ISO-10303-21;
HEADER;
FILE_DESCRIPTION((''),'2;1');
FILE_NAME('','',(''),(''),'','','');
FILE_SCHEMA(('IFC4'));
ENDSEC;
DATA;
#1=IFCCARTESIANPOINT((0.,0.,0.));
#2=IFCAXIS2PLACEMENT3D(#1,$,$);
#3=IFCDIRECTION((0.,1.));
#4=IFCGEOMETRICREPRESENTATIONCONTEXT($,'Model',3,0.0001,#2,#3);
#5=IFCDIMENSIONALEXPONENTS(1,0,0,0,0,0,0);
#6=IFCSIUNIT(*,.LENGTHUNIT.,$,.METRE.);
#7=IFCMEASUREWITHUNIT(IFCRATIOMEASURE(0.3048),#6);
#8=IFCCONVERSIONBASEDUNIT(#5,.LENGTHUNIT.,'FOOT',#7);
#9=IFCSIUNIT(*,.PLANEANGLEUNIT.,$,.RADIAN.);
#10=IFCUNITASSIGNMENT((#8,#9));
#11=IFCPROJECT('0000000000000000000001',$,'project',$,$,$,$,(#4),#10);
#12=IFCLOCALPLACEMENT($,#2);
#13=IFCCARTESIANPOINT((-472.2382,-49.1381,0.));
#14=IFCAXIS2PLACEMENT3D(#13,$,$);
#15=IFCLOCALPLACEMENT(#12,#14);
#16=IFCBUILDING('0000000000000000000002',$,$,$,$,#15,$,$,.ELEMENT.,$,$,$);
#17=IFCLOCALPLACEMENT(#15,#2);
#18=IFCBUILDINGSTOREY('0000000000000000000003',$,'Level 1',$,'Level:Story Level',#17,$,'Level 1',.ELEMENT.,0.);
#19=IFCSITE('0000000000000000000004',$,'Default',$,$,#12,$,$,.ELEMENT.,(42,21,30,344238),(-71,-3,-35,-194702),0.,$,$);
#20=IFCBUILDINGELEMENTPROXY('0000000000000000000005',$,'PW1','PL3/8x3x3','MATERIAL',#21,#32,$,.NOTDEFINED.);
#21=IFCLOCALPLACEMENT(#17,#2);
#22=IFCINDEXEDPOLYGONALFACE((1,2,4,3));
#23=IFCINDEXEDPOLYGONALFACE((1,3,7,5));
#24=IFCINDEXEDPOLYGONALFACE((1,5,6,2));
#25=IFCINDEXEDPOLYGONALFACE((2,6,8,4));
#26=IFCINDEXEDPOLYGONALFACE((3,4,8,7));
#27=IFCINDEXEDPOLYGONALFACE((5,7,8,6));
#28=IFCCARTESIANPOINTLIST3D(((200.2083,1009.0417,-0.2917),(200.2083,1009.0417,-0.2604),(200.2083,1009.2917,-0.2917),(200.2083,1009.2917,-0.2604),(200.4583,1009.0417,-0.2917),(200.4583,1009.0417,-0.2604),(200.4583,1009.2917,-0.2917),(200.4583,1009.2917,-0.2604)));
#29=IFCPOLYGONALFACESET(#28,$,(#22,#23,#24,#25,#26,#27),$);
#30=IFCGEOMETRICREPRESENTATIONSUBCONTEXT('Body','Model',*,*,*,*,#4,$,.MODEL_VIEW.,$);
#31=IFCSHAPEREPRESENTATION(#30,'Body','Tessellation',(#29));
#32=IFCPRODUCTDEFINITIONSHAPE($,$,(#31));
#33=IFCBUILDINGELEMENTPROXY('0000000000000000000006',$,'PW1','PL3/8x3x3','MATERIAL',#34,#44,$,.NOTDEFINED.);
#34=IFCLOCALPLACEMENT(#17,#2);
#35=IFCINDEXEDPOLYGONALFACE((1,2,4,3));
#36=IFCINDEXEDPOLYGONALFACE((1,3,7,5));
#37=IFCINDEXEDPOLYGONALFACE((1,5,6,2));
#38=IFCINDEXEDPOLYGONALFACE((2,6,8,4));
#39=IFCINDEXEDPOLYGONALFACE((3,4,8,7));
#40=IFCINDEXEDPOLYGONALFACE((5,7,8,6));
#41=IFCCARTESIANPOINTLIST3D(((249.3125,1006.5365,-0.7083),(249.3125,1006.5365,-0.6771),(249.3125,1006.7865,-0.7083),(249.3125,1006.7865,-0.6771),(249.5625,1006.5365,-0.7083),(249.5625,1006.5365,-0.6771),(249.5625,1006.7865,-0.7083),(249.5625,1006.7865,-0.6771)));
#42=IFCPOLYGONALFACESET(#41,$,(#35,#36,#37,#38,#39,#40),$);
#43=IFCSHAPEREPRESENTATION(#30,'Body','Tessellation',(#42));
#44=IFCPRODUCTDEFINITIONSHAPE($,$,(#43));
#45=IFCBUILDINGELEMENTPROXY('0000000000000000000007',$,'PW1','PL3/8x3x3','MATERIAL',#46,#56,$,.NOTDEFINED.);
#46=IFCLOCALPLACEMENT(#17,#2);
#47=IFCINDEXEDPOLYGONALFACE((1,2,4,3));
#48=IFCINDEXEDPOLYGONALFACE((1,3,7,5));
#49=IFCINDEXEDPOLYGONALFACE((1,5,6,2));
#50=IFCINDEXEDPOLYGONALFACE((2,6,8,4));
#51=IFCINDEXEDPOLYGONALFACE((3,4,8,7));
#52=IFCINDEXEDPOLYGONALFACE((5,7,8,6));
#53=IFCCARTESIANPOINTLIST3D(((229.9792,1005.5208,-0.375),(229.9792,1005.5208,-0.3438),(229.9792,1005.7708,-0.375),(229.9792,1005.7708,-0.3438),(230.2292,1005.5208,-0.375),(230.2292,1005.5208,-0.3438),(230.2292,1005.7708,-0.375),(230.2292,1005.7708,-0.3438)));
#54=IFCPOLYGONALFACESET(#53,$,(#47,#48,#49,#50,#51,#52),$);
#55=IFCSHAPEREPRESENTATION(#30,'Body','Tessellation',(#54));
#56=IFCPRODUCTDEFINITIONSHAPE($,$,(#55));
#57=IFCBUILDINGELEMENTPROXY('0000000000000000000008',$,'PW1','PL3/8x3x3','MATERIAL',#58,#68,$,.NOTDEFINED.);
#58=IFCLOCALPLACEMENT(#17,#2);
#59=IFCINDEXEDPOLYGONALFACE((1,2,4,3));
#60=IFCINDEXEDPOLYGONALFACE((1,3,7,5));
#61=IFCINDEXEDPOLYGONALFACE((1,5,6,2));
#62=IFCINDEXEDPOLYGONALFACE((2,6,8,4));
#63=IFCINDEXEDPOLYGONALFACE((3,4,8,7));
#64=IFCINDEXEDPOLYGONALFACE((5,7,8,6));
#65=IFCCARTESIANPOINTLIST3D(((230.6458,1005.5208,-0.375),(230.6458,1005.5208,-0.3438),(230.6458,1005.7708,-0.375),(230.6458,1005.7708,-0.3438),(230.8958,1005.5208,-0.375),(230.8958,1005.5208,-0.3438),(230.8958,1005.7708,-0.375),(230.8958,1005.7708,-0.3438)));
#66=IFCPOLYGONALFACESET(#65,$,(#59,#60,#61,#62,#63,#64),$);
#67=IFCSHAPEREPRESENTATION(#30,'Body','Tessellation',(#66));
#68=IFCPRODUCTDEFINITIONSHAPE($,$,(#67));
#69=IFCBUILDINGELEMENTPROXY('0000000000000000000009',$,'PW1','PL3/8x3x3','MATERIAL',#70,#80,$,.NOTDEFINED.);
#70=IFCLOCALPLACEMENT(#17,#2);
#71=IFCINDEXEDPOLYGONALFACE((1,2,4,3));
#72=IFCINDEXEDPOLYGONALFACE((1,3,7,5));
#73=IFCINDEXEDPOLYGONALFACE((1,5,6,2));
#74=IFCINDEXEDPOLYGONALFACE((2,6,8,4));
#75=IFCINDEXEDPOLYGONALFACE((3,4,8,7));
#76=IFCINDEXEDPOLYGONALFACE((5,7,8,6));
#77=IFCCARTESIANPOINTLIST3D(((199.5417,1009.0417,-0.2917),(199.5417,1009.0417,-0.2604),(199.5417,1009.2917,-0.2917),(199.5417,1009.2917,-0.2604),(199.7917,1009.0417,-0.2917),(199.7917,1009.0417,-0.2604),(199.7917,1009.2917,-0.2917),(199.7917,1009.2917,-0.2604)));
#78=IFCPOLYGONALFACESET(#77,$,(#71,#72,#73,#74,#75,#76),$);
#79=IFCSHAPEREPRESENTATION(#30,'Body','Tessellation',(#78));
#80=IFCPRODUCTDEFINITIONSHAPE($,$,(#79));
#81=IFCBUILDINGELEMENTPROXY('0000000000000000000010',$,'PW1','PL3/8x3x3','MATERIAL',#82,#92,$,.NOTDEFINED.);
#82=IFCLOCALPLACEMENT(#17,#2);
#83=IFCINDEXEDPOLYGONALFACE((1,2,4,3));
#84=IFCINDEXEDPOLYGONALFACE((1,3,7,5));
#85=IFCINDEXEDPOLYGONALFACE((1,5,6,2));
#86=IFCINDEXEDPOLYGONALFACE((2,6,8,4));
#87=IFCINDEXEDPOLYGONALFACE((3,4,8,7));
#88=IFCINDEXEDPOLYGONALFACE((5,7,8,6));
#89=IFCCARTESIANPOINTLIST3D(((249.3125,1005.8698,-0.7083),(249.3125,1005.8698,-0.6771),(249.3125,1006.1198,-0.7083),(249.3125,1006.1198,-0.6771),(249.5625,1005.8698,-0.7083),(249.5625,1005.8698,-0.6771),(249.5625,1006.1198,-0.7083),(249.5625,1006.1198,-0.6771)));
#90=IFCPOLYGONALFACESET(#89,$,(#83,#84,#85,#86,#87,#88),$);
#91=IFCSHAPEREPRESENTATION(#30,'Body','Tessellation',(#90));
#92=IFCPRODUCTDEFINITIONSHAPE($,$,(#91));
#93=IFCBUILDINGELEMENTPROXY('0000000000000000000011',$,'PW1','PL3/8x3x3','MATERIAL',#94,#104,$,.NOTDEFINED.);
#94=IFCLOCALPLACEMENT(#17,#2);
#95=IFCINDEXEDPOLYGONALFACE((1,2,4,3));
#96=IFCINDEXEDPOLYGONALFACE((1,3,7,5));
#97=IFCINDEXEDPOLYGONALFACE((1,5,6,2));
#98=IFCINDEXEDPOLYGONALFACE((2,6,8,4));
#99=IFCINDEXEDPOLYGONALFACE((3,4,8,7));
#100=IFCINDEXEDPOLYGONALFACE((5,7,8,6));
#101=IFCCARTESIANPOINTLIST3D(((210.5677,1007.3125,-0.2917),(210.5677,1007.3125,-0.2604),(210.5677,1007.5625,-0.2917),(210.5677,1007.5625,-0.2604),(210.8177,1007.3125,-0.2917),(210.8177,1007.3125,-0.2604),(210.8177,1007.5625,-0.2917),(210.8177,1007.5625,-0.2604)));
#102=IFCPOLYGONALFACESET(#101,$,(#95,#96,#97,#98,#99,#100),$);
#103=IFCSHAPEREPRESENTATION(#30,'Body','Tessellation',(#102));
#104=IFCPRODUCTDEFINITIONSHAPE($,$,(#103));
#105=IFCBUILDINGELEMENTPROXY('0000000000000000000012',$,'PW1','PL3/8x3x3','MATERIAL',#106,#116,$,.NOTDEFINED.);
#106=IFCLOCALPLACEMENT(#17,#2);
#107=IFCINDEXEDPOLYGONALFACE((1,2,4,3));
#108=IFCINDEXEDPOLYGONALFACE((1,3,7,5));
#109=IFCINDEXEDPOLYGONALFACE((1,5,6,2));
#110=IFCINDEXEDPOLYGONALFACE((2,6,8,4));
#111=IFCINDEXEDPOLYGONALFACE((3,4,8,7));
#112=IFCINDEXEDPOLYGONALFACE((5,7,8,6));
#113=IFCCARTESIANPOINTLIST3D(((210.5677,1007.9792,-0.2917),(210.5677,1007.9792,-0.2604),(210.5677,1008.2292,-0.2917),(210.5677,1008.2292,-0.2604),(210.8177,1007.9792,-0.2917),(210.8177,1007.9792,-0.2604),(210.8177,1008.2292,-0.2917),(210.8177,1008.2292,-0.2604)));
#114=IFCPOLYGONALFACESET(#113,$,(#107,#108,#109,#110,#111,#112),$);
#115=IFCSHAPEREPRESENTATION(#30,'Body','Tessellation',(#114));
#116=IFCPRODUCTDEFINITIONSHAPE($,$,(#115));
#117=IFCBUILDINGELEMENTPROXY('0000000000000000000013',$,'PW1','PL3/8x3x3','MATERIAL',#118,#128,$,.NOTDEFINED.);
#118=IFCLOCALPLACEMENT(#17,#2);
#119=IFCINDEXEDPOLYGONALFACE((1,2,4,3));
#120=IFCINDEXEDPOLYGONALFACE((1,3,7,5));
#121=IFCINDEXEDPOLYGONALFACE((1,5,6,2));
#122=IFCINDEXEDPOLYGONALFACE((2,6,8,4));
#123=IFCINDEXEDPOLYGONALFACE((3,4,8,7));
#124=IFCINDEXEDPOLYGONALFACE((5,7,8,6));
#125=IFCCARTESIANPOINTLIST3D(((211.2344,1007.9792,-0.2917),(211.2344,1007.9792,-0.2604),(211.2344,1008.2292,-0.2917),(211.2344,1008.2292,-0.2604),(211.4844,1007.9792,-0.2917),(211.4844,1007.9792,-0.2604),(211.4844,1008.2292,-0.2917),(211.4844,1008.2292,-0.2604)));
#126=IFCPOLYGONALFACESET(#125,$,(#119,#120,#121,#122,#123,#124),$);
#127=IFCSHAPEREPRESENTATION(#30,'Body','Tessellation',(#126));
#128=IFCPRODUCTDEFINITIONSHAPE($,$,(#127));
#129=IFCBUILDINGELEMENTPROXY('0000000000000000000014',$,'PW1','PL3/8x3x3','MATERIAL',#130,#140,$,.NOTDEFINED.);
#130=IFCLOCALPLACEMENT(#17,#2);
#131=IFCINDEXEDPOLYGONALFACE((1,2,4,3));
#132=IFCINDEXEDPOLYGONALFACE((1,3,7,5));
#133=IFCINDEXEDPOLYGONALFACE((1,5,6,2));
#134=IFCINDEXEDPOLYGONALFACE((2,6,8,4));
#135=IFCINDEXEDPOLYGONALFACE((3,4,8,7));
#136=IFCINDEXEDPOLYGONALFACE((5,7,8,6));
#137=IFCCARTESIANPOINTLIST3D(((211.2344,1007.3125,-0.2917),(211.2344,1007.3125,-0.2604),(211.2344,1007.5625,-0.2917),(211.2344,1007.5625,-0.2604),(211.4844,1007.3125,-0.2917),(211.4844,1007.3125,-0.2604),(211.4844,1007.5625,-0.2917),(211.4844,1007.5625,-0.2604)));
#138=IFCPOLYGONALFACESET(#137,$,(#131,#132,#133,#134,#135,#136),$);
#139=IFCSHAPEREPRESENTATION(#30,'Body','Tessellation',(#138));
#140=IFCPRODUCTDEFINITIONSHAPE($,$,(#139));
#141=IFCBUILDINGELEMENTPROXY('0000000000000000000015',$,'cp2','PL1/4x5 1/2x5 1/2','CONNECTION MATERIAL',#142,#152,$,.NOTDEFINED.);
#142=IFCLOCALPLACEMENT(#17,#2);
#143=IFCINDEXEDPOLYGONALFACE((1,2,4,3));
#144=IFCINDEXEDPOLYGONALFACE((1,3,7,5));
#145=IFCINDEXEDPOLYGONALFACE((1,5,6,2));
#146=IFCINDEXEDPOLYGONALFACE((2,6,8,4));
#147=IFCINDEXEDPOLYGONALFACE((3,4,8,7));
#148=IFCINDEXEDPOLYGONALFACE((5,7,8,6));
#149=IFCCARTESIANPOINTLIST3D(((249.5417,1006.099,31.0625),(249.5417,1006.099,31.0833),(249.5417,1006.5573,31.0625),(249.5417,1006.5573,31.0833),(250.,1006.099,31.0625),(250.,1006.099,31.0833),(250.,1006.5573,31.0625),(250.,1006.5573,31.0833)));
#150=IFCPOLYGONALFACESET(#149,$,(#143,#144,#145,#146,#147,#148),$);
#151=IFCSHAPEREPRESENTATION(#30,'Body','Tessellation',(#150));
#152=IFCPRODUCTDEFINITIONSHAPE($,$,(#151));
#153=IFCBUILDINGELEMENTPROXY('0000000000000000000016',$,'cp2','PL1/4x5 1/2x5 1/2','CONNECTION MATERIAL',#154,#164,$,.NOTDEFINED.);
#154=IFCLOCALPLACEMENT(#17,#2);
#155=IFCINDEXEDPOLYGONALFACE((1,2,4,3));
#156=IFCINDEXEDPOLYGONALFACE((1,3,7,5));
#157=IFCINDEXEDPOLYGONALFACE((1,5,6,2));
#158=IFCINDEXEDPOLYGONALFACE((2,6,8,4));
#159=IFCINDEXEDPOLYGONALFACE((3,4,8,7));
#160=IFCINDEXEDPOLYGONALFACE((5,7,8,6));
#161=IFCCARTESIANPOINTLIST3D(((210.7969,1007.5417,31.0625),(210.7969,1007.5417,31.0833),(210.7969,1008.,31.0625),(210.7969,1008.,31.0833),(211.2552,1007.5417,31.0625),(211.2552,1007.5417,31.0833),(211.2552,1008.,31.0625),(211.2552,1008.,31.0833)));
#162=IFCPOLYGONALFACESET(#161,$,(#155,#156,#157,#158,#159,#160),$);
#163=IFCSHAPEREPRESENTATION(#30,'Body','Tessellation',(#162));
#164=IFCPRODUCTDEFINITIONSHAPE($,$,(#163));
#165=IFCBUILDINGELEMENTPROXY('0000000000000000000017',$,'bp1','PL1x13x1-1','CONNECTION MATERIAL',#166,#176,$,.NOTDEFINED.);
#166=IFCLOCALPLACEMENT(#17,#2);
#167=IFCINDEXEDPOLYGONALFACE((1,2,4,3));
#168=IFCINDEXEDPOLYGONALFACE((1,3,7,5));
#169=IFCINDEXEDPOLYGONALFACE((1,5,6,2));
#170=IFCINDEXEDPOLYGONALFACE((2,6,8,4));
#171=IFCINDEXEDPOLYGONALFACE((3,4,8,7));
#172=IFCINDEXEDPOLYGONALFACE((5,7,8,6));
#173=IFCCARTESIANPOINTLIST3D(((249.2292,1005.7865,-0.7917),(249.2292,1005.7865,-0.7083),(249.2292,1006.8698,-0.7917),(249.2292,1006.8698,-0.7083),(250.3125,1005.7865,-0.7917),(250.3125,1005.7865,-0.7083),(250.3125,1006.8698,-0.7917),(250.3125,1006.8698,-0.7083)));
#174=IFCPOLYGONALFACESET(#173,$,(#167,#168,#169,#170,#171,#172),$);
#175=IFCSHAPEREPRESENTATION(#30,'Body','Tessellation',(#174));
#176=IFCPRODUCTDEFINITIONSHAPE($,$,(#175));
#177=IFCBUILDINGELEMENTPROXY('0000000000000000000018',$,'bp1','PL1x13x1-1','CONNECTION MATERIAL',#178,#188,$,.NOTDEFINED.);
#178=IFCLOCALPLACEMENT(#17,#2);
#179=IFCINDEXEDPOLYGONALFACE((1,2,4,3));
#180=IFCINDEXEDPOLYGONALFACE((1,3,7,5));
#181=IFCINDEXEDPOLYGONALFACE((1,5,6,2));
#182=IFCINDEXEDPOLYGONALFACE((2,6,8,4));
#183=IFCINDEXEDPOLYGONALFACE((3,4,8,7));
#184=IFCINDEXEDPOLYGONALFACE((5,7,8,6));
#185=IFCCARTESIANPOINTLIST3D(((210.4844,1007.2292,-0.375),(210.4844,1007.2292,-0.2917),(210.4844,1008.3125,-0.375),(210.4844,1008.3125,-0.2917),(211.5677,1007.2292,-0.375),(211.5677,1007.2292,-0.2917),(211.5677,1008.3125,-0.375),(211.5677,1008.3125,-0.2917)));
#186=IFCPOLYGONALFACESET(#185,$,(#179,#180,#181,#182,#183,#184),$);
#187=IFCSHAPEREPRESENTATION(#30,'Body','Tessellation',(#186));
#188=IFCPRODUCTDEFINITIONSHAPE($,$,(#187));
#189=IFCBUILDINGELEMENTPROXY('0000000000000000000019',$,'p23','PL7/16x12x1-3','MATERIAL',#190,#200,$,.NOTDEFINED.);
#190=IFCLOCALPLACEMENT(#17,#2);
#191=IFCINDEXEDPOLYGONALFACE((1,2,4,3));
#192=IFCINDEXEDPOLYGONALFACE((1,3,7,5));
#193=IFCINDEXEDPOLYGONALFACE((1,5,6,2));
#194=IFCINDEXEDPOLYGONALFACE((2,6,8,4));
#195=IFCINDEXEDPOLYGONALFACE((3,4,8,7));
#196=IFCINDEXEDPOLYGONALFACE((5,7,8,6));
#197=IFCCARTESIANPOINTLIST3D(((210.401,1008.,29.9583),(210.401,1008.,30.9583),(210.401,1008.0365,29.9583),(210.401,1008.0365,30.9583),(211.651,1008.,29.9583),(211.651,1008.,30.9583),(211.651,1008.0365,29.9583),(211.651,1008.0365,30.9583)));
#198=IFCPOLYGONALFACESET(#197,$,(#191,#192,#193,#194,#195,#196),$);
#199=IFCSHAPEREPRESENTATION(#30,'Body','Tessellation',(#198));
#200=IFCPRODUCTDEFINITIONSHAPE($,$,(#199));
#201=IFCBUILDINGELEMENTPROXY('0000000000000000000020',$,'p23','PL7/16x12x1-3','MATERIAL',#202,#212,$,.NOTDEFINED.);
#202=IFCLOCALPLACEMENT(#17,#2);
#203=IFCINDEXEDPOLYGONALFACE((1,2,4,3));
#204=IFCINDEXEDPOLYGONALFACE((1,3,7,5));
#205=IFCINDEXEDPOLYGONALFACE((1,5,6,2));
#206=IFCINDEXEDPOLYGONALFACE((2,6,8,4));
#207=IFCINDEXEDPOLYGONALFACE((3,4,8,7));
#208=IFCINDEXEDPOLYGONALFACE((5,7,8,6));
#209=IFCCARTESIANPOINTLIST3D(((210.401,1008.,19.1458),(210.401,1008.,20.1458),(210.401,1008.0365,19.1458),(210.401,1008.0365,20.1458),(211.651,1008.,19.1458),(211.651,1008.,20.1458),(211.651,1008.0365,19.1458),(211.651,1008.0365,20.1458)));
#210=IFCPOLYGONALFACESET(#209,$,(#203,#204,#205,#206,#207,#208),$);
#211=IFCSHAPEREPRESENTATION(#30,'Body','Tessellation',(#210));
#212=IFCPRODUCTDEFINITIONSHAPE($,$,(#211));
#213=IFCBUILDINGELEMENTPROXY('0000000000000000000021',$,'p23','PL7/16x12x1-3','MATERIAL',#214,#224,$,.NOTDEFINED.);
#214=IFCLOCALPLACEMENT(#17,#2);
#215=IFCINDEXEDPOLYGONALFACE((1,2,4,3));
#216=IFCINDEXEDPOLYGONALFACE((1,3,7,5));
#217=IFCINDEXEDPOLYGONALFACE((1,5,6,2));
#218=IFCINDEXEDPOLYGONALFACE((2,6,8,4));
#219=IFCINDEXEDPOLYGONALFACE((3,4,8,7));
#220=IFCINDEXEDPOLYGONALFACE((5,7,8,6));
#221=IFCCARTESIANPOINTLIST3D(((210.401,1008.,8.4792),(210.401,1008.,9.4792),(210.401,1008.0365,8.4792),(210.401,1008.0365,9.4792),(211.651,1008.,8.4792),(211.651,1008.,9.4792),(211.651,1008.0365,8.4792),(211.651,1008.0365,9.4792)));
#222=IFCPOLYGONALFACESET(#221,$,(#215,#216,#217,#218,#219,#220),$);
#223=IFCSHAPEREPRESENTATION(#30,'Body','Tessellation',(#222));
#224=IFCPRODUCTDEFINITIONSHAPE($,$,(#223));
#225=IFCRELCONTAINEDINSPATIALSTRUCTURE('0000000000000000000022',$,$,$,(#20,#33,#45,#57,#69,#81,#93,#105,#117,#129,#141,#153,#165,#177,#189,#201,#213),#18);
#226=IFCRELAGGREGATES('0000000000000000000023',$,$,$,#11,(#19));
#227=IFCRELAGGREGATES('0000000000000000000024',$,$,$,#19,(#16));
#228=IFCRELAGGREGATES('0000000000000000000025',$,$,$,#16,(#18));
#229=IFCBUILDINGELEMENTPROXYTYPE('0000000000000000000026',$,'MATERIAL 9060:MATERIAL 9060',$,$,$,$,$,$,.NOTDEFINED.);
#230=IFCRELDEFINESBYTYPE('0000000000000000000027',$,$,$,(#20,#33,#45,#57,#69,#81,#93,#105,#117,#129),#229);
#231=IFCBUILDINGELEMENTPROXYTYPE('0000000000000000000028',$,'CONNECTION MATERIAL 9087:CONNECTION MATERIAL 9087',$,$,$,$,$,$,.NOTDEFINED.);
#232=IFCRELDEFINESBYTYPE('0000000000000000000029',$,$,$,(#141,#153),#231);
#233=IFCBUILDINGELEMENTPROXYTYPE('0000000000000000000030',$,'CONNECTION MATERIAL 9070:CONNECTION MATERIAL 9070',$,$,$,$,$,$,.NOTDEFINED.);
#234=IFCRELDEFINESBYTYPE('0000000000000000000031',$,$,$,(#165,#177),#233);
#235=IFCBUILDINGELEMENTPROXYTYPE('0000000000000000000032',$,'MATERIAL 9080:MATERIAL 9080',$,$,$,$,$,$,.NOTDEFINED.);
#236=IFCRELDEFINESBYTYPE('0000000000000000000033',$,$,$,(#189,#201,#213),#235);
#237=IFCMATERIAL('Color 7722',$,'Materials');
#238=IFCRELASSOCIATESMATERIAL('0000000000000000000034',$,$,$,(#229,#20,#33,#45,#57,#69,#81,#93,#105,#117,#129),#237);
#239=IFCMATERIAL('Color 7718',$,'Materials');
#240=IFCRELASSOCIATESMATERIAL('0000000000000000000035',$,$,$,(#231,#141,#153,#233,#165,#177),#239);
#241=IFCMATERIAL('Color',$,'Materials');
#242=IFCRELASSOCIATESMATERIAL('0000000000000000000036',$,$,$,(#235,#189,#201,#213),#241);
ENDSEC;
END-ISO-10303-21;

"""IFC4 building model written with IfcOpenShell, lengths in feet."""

from ifc_helpers import new_model, entity, si_unit, converted_unit, direction, frame, origin, origin_2d_with_axis, place, context, subcontext, project, spatial, rectangle, extrude, source, transform, mapped, material, type_object, type_shapes, element, save


model = new_model("IFC4")

# Units and contexts
model_context = context("Model", 3, precision=0.0001, world=origin(), true_north=direction((0.0, 1.0)))
body_context = subcontext(model_context, "Body", "Model", "MODEL_VIEW")
ifc_project = project(units=[converted_unit("LENGTHUNIT", "FOOT", entity("IfcRatioMeasure", 0.3048), si_unit("LENGTHUNIT", "METRE"), dimensions=[1, 0, 0, 0, 0, 0, 0]), si_unit("PLANEANGLEUNIT", "RADIAN")], contexts=[model_context])

# Site, building, storey
site_placement = place(None, origin())
site = spatial("IfcSite", under=ifc_project, at=site_placement, Name="Default", CompositionType="ELEMENT", RefLatitude=(42, 21, 30, 344238), RefLongitude=(-71, -3, -35, -194702), RefElevation=0.0)
building_placement = place(site_placement, frame((-472.2382, -49.1381, 0.0)))
building = spatial("IfcBuilding", under=site, at=building_placement, CompositionType="ELEMENT")
storey_placement = place(building_placement, origin())
storey = spatial("IfcBuildingStorey", under=building, at=storey_placement, Name="Level 1", ObjectType="Level:Story Level", LongName="Level 1", CompositionType="ELEMENT", Elevation=0.0)

# Building element proxies
ifc_material_1 = material(Name="Color", Category="Materials")
ifc_material_2 = material(Name="Color 7722", Category="Materials")
building_element_proxy_type_1 = type_object("IfcBuildingElementProxyType", Name="MATERIAL 9060:MATERIAL 9060", PredefinedType="NOTDEFINED", material=ifc_material_2)
shared_shape_1 = source(origin(), body_context, "Body", "SweptSolid", [
    extrude(rectangle(XDim=0.25, YDim=0.25, at=origin_2d_with_axis()), frame((0.125, -0.125, 0.0)), (0.0, 0.0, 1.0), 0.0312),
])
type_shapes(building_element_proxy_type_1, [shared_shape_1])
for number, where, z_axis, x_axis, name in (
    (1, (200.2083, 1009.2917, -0.2604), (0.0, 0.0, -1.0), (0.0, -1.0, 0.0), "PW1"),
    (2, (249.3125, 1006.7865, -0.6771), (0.0, 0.0, -1.0), (0.0, -1.0, 0.0), "PW1"),
    (3, (229.9792, 1005.7708, -0.3438), (0.0, 0.0, -1.0), (0.0, -1.0, 0.0), "PW1"),
    (4, (230.6458, 1005.7708, -0.3438), (0.0, 0.0, -1.0), (0.0, -1.0, 0.0), "PW1"),
    (5, (199.5417, 1009.2917, -0.2604), (0.0, 0.0, -1.0), (0.0, -1.0, 0.0), "PW1"),
    (6, (249.3125, 1006.1198, -0.6771), (0.0, 0.0, -1.0), (0.0, -1.0, 0.0), "PW1"),
    (7, (210.5677, 1007.5625, -0.2604), (0.0, 0.0, -1.0), (0.0, -1.0, 0.0), "PW1"),
    (8, (210.5677, 1008.2292, -0.2604), (0.0, 0.0, -1.0), (0.0, -1.0, 0.0), "PW1"),
    (9, (211.2344, 1008.2292, -0.2604), (0.0, 0.0, -1.0), (0.0, -1.0, 0.0), "PW1"),
    (10, (211.2344, 1007.5625, -0.2604), (0.0, 0.0, -1.0), (0.0, -1.0, 0.0), "PW1"),
):
    element("IfcBuildingElementProxy", number, at=place(building_placement, frame(where, z_axis=z_axis, x_axis=x_axis)), inside=storey, type_object=building_element_proxy_type_1, material=ifc_material_2, Name=name, Description="PL3/8x3x3", ObjectType="MATERIAL", PredefinedType="NOTDEFINED", context=body_context, shape_type="MappedRepresentation", body=[
        mapped(shared_shape_1, transform((0.0, 0.0, 0.0), scale=1.0)),
    ])
ifc_material_3 = material(Name="Color 7718", Category="Materials")
building_element_proxy_type_2 = type_object("IfcBuildingElementProxyType", Name="CONNECTION MATERIAL 9087:CONNECTION MATERIAL 9087", PredefinedType="NOTDEFINED", material=ifc_material_3)
shared_shape_2 = source(origin(), body_context, "Body", "SweptSolid", [
    extrude(rectangle(XDim=0.4583, YDim=0.4583, at=origin_2d_with_axis()), frame((0.0, 0.0, -0.0208)), (0.0, 0.0, 1.0), 0.0208),
])
type_shapes(building_element_proxy_type_2, [shared_shape_2])
for number, where, z_axis, x_axis, name in (
    (11, (249.7708, 1006.3281, 31.0625), (0.0, 0.0, -1.0), (1.0, 0.0, 0.0), "cp2"),
    (12, (211.026, 1007.7708, 31.0625), (0.0, 0.0, -1.0), (1.0, 0.0, 0.0), "cp2"),
):
    element("IfcBuildingElementProxy", number, at=place(building_placement, frame(where, z_axis=z_axis, x_axis=x_axis)), inside=storey, type_object=building_element_proxy_type_2, material=ifc_material_3, Name=name, Description="PL1/4x5 1/2x5 1/2", ObjectType="CONNECTION MATERIAL", PredefinedType="NOTDEFINED", context=body_context, shape_type="MappedRepresentation", body=[
        mapped(shared_shape_2, transform((0.0, 0.0, 0.0), scale=1.0)),
    ])
building_element_proxy_type_3 = type_object("IfcBuildingElementProxyType", Name="CONNECTION MATERIAL 9070:CONNECTION MATERIAL 9070", PredefinedType="NOTDEFINED", material=ifc_material_3)
shared_shape_3 = source(origin(), body_context, "Body", "SweptSolid", [
    extrude(rectangle(XDim=1.0833, YDim=1.0833, at=origin_2d_with_axis()), frame((0.0, 0.0, -0.0833)), (0.0, 0.0, 1.0), 0.0833),
])
type_shapes(building_element_proxy_type_3, [shared_shape_3])
for number, where, name in (
    (13, (249.7708, 1006.3281, -0.7083), "bp1"),
    (14, (211.026, 1007.7708, -0.2917), "bp1"),
):
    element("IfcBuildingElementProxy", number, at=place(building_placement, frame(where)), inside=storey, type_object=building_element_proxy_type_3, material=ifc_material_3, Name=name, Description="PL1x13x1-1", ObjectType="CONNECTION MATERIAL", PredefinedType="NOTDEFINED", context=body_context, shape_type="MappedRepresentation", body=[
        mapped(shared_shape_3, transform((0.0, 0.0, 0.0), scale=1.0)),
    ])
building_element_proxy_type_4 = type_object("IfcBuildingElementProxyType", Name="MATERIAL 9080:MATERIAL 9080", PredefinedType="NOTDEFINED", material=ifc_material_1)
shared_shape_4 = source(origin(), body_context, "Body", "SweptSolid", [
    extrude(rectangle(XDim=1.25, YDim=1.0, at=origin_2d_with_axis()), frame((0.625, -0.5, 0.0)), (0.0, 0.0, 1.0), 0.0365),
])
type_shapes(building_element_proxy_type_4, [shared_shape_4])
for number, where, z_axis, x_axis, name in (
    (15, (210.401, 1008.0365, 30.9583), (0.0, -1.0, 0.0), (1.0, 0.0, 0.0), "p23"),
    (16, (210.401, 1008.0365, 20.1458), (0.0, -1.0, 0.0), (1.0, 0.0, 0.0), "p23"),
    (17, (210.401, 1008.0365, 9.4792), (0.0, -1.0, 0.0), (1.0, 0.0, 0.0), "p23"),
):
    element("IfcBuildingElementProxy", number, at=place(building_placement, frame(where, z_axis=z_axis, x_axis=x_axis)), inside=storey, type_object=building_element_proxy_type_4, material=ifc_material_1, Name=name, Description="PL7/16x12x1-3", ObjectType="MATERIAL", PredefinedType="NOTDEFINED", context=body_context, shape_type="MappedRepresentation", body=[
        mapped(shared_shape_4, transform((0.0, 0.0, 0.0), scale=1.0)),
    ])

save(model, "model.ifc")
